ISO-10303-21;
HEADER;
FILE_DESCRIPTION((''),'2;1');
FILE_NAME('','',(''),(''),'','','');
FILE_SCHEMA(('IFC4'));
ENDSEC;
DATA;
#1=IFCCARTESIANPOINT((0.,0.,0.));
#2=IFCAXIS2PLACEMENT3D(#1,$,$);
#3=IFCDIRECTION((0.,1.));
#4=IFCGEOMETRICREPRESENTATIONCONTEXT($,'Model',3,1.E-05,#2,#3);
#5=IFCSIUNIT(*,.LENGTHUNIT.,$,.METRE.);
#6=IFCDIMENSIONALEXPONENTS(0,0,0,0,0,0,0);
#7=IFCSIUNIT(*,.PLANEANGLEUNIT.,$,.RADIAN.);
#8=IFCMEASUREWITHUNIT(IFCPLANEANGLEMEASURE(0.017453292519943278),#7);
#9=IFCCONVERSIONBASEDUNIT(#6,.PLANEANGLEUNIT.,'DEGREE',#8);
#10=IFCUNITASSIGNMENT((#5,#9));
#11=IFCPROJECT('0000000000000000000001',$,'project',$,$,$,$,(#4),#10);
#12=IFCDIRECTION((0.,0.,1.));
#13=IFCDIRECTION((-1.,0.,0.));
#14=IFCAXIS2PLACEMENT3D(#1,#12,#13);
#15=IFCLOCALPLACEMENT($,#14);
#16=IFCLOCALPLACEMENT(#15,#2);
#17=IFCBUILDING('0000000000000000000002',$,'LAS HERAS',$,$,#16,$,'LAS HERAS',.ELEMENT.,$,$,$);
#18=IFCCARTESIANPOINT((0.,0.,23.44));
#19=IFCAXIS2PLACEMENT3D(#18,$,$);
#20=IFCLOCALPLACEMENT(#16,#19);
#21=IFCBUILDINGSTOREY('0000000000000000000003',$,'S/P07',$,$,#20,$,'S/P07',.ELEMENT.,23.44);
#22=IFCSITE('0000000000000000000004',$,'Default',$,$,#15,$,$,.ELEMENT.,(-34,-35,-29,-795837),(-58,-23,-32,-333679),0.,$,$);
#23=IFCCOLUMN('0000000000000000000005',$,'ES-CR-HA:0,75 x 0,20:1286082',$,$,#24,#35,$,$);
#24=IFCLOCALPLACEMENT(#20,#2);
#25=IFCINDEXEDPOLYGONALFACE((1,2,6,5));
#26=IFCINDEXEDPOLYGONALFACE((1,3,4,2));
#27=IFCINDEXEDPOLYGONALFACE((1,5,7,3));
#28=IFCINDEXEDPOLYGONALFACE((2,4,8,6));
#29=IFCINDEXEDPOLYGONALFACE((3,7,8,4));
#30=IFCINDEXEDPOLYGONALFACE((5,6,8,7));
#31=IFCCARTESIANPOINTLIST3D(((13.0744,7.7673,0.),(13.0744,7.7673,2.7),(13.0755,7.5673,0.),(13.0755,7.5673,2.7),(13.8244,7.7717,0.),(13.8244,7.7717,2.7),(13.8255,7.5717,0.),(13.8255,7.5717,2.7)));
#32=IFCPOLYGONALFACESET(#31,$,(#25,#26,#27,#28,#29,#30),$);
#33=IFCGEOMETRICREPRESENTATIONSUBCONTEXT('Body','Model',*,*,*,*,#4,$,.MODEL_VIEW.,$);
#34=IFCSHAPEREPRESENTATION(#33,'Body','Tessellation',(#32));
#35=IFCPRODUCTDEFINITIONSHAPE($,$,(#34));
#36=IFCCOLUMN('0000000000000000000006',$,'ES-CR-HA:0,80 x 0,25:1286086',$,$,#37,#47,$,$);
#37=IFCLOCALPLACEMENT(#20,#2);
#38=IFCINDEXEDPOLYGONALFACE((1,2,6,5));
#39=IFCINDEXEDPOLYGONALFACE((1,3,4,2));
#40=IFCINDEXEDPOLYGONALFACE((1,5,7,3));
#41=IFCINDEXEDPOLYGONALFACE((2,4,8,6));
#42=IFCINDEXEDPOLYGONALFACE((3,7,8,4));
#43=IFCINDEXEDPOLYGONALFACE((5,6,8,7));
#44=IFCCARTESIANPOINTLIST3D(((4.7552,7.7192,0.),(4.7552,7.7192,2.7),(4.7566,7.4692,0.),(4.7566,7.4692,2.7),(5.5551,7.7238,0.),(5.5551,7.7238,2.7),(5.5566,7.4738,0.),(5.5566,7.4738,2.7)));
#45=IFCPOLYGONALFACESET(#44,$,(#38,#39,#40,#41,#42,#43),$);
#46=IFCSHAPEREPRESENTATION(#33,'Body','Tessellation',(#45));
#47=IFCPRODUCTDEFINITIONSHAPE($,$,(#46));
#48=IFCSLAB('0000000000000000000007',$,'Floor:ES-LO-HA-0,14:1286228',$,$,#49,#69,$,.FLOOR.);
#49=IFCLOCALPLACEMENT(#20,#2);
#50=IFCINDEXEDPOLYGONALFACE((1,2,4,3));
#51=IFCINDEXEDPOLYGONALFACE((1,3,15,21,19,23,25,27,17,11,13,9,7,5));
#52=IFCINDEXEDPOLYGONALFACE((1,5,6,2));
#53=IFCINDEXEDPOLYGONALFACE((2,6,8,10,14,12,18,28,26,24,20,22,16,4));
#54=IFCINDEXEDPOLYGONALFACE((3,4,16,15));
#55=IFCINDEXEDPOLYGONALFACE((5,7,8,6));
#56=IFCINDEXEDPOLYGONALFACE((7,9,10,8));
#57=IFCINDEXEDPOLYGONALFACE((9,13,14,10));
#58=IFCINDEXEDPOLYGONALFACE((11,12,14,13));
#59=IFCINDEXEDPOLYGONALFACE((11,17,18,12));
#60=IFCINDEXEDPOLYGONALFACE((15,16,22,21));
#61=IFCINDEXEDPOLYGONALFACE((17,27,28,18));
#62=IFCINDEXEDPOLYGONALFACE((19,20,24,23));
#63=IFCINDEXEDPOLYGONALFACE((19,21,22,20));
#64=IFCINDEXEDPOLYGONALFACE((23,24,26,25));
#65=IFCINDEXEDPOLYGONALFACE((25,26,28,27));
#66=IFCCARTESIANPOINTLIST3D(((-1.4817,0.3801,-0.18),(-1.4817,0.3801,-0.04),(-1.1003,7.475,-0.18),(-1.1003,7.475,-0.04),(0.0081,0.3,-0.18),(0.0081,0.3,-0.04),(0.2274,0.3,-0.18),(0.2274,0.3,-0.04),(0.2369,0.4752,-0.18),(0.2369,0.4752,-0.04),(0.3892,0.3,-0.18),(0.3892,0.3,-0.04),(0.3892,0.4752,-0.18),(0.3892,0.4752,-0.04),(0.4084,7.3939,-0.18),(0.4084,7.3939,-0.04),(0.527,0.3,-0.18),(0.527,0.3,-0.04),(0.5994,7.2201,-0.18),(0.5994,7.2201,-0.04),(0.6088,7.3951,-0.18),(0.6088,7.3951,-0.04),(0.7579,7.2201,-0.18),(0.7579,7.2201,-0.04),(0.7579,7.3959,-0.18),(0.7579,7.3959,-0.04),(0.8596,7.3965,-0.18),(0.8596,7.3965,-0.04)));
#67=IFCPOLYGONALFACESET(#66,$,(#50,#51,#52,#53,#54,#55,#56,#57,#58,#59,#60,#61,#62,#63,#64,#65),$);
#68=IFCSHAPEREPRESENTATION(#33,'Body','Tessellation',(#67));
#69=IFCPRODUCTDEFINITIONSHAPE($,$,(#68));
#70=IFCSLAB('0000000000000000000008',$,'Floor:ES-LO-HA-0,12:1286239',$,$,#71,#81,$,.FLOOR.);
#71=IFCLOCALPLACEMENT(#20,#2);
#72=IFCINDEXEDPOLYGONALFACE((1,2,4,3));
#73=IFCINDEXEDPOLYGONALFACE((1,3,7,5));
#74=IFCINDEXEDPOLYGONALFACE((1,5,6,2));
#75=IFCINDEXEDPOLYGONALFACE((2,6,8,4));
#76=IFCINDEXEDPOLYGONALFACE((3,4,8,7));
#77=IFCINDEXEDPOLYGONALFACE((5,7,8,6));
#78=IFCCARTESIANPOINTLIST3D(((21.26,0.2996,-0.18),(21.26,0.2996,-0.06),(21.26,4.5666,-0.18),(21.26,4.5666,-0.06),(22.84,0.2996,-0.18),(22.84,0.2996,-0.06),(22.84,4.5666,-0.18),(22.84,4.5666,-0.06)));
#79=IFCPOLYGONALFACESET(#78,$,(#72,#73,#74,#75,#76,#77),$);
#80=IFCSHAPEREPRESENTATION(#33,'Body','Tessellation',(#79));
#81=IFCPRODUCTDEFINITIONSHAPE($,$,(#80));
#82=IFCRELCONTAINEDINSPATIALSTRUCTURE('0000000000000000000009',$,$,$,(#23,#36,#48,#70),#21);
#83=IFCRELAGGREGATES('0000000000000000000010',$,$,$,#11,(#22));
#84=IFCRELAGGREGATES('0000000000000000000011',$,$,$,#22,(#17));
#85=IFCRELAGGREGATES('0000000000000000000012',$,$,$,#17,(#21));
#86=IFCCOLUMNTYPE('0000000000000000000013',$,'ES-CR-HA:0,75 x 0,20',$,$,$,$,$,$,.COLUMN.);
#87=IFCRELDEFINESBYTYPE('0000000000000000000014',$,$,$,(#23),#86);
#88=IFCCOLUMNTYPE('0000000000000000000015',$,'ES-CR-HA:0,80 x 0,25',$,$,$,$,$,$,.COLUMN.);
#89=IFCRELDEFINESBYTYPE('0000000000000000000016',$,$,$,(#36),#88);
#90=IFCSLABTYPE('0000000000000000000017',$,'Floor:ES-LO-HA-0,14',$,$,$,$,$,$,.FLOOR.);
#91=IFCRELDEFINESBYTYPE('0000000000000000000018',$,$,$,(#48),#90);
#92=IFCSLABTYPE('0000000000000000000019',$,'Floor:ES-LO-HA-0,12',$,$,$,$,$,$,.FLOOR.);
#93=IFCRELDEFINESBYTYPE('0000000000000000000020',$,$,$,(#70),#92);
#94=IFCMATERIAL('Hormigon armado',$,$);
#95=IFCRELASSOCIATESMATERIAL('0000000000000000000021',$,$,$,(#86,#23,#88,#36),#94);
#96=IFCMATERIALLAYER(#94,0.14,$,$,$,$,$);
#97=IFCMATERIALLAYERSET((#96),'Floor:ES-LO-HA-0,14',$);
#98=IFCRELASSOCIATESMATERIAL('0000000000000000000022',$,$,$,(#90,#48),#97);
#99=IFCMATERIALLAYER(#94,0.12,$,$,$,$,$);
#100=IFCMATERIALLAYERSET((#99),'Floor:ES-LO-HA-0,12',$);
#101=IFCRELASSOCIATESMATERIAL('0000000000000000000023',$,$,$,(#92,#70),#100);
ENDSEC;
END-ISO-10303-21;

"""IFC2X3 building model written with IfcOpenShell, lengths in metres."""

from ifc_helpers import new_model, entity, si_unit, converted_unit, direction, frame, frame_2d, origin, place, context, subcontext, project, spatial, polyline, rectangle, outline, extrude, source, transform, mapped, material, layer, layer_set, layer_usage, type_object, type_shapes, element, save


model = new_model("IFC2X3")

# Units and contexts
model_context = context("Model", 3, precision=1e-05, world=origin(), true_north=direction((0.0, 1.0)))
body_context = subcontext(model_context, "Body", "Model", "MODEL_VIEW")
ifc_project = project(units=[si_unit("LENGTHUNIT", "METRE"), converted_unit("PLANEANGLEUNIT", "DEGREE", entity("IfcPlaneAngleMeasure", 0.017453292519943278), si_unit("PLANEANGLEUNIT", "RADIAN"), dimensions=[0, 0, 0, 0, 0, 0, 0])], contexts=[model_context])

# Site, building, storey
site_placement = place(None, frame((0.0, 0.0, 0.0), z_axis=(0.0, 0.0, 1.0), x_axis=(-1.0, 0.0, 0.0)))
site = spatial("IfcSite", under=ifc_project, at=site_placement, Name="Default", CompositionType="ELEMENT", RefLatitude=(-34, -35, -29, -795837), RefLongitude=(-58, -23, -32, -333679), RefElevation=0.0)
building_placement = place(site_placement, origin())
building = spatial("IfcBuilding", under=site, at=building_placement, Name="LAS HERAS", LongName="LAS HERAS", CompositionType="ELEMENT")
storey_placement = place(building_placement, frame((0.0, 0.0, 23.44)))
storey = spatial("IfcBuildingStorey", under=building, at=storey_placement, Name="S/P07", LongName="S/P07", CompositionType="ELEMENT", Elevation=23.44)

# Columns
ifc_material = material(Name="Hormigon armado")
column_type_1 = type_object("IfcColumnType", Name="ES-CR-HA:0,75 x 0,20", PredefinedType="COLUMN", material=ifc_material)
shared_shape_1 = source(origin(), body_context, "Body", "SweptSolid", [
    extrude(rectangle(XDim=0.75, YDim=0.2, at=frame_2d((0.0, 0.0), x_axis=(1.0, 0.0))), frame((13.4499, 7.6695, 23.44), z_axis=(0.0, 0.0, 1.0), x_axis=(-0.999983, -0.005788, 0.0)), (0.0, 0.0, 1.0), 2.7),
])
type_shapes(column_type_1, [shared_shape_1])
column_1_placement = place(storey_placement, frame((0.0, 0.0, -23.44)))
element("IfcColumn", 1, at=column_1_placement, inside=storey, type_object=column_type_1, material=ifc_material, Name="ES-CR-HA:0,75 x 0,20:1286082", context=body_context, shape_type="MappedRepresentation", body=[
    mapped(shared_shape_1, transform((0.0, 0.0, 0.0), scale=1.0)),
])
column_type_2 = type_object("IfcColumnType", Name="ES-CR-HA:0,80 x 0,25", PredefinedType="COLUMN", material=ifc_material)
shared_shape_2 = source(origin(), body_context, "Body", "SweptSolid", [
    extrude(rectangle(XDim=0.8, YDim=0.25, at=frame_2d((0.0, 0.0), x_axis=(1.0, 0.0))), frame((5.1559, 7.5965, 23.44), z_axis=(0.0, 0.0, 1.0), x_axis=(-0.999983, -0.005788, 0.0)), (0.0, 0.0, 1.0), 2.7),
])
type_shapes(column_type_2, [shared_shape_2])
column_2_placement = place(storey_placement, frame((0.0, 0.0, -23.44)))
element("IfcColumn", 2, at=column_2_placement, inside=storey, type_object=column_type_2, material=ifc_material, Name="ES-CR-HA:0,80 x 0,25:1286086", context=body_context, shape_type="MappedRepresentation", body=[
    mapped(shared_shape_2, transform((0.0, 0.0, 0.0), scale=1.0)),
])

# Slab, openings
ifc_layer_1 = layer(ifc_material, 0.14)
ifc_layer_set_1 = layer_set([ifc_layer_1], Name="Floor:ES-LO-HA-0,14")
ifc_layer_usage_1 = layer_usage(ifc_layer_set_1, "AXIS3", "POSITIVE", 0.0)
slab_type_1 = type_object("IfcSlabType", Name="Floor:ES-LO-HA-0,14", PredefinedType="FLOOR", material=ifc_layer_set_1)
slab_1_placement = place(storey_placement, origin())
slab_1 = element("IfcSlab", 3, at=slab_1_placement, inside=storey, type_object=slab_type_1, material=ifc_layer_usage_1, Name="Floor:ES-LO-HA-0,14:1286228", PredefinedType="FLOOR", context=body_context, shape_type="SweptSolid", body=[
    extrude(outline(polyline([(-0.2993, -3.5591), (-0.1615, -3.5591), (-0.1615, -3.3839), (-0.0091, -3.3839), (0.0003, -3.5591), (0.2196, -3.5591), (1.7094, -3.479), (1.328, 3.6159), (-0.1807, 3.5348), (-0.3811, 3.536), (-0.3717, 3.3611), (-0.5302, 3.3611), (-0.5302, 3.5368), (-0.6319, 3.5374), (-0.2993, -3.5591)])), frame((0.2277, 3.8591, -0.04), z_axis=(0.0, 0.0, -1.0), x_axis=(-1.0, 0.0, 0.0)), (0.0, 0.0, 1.0), 0.14),
])
opening_1_placement = place(slab_1_placement, origin())
element("IfcOpeningElement", 4, at=opening_1_placement, cuts=slab_1, ObjectType="Opening", context=body_context, shape_type="SweptSolid", body=[
    extrude(outline(polyline([(0.2369, 0.4752), (0.2274, 0.3), (0.3892, 0.3), (0.3892, 0.4752), (0.2369, 0.4752)])), frame((0.0, 0.0, -0.04)), (0.0, 0.0, -1.0), 0.14),
])
opening_2_placement = place(slab_1_placement, origin())
element("IfcOpeningElement", 5, at=opening_2_placement, cuts=slab_1, ObjectType="Opening", context=body_context, shape_type="SweptSolid", body=[
    extrude(outline(polyline([(0.7579, 7.2201), (0.7579, 7.3959), (0.6088, 7.3951), (0.5994, 7.2201), (0.7579, 7.2201)])), frame((0.0, 0.0, -0.04)), (0.0, 0.0, -1.0), 0.14),
])

# Slab
ifc_layer_2 = layer(ifc_material, 0.12)
ifc_layer_set_2 = layer_set([ifc_layer_2], Name="Floor:ES-LO-HA-0,12")
ifc_layer_usage_2 = layer_usage(ifc_layer_set_2, "AXIS3", "POSITIVE", 0.0)
slab_type_2 = type_object("IfcSlabType", Name="Floor:ES-LO-HA-0,12", PredefinedType="FLOOR", material=ifc_layer_set_2)
slab_2_placement = place(storey_placement, origin())
element("IfcSlab", 6, at=slab_2_placement, inside=storey, type_object=slab_type_2, material=ifc_layer_usage_2, Name="Floor:ES-LO-HA-0,12:1286239", PredefinedType="FLOOR", context=body_context, shape_type="SweptSolid", body=[
    extrude(rectangle(XDim=4.2671, YDim=1.58, at=frame_2d((0.0, 0.0), x_axis=(1.0, 0.0))), frame((22.05, 2.4331, -0.06), z_axis=(0.0, 0.0, -1.0), x_axis=(0.0, 1.0, 0.0)), (0.0, 0.0, 1.0), 0.12),
])

save(model, "model.ifc")
